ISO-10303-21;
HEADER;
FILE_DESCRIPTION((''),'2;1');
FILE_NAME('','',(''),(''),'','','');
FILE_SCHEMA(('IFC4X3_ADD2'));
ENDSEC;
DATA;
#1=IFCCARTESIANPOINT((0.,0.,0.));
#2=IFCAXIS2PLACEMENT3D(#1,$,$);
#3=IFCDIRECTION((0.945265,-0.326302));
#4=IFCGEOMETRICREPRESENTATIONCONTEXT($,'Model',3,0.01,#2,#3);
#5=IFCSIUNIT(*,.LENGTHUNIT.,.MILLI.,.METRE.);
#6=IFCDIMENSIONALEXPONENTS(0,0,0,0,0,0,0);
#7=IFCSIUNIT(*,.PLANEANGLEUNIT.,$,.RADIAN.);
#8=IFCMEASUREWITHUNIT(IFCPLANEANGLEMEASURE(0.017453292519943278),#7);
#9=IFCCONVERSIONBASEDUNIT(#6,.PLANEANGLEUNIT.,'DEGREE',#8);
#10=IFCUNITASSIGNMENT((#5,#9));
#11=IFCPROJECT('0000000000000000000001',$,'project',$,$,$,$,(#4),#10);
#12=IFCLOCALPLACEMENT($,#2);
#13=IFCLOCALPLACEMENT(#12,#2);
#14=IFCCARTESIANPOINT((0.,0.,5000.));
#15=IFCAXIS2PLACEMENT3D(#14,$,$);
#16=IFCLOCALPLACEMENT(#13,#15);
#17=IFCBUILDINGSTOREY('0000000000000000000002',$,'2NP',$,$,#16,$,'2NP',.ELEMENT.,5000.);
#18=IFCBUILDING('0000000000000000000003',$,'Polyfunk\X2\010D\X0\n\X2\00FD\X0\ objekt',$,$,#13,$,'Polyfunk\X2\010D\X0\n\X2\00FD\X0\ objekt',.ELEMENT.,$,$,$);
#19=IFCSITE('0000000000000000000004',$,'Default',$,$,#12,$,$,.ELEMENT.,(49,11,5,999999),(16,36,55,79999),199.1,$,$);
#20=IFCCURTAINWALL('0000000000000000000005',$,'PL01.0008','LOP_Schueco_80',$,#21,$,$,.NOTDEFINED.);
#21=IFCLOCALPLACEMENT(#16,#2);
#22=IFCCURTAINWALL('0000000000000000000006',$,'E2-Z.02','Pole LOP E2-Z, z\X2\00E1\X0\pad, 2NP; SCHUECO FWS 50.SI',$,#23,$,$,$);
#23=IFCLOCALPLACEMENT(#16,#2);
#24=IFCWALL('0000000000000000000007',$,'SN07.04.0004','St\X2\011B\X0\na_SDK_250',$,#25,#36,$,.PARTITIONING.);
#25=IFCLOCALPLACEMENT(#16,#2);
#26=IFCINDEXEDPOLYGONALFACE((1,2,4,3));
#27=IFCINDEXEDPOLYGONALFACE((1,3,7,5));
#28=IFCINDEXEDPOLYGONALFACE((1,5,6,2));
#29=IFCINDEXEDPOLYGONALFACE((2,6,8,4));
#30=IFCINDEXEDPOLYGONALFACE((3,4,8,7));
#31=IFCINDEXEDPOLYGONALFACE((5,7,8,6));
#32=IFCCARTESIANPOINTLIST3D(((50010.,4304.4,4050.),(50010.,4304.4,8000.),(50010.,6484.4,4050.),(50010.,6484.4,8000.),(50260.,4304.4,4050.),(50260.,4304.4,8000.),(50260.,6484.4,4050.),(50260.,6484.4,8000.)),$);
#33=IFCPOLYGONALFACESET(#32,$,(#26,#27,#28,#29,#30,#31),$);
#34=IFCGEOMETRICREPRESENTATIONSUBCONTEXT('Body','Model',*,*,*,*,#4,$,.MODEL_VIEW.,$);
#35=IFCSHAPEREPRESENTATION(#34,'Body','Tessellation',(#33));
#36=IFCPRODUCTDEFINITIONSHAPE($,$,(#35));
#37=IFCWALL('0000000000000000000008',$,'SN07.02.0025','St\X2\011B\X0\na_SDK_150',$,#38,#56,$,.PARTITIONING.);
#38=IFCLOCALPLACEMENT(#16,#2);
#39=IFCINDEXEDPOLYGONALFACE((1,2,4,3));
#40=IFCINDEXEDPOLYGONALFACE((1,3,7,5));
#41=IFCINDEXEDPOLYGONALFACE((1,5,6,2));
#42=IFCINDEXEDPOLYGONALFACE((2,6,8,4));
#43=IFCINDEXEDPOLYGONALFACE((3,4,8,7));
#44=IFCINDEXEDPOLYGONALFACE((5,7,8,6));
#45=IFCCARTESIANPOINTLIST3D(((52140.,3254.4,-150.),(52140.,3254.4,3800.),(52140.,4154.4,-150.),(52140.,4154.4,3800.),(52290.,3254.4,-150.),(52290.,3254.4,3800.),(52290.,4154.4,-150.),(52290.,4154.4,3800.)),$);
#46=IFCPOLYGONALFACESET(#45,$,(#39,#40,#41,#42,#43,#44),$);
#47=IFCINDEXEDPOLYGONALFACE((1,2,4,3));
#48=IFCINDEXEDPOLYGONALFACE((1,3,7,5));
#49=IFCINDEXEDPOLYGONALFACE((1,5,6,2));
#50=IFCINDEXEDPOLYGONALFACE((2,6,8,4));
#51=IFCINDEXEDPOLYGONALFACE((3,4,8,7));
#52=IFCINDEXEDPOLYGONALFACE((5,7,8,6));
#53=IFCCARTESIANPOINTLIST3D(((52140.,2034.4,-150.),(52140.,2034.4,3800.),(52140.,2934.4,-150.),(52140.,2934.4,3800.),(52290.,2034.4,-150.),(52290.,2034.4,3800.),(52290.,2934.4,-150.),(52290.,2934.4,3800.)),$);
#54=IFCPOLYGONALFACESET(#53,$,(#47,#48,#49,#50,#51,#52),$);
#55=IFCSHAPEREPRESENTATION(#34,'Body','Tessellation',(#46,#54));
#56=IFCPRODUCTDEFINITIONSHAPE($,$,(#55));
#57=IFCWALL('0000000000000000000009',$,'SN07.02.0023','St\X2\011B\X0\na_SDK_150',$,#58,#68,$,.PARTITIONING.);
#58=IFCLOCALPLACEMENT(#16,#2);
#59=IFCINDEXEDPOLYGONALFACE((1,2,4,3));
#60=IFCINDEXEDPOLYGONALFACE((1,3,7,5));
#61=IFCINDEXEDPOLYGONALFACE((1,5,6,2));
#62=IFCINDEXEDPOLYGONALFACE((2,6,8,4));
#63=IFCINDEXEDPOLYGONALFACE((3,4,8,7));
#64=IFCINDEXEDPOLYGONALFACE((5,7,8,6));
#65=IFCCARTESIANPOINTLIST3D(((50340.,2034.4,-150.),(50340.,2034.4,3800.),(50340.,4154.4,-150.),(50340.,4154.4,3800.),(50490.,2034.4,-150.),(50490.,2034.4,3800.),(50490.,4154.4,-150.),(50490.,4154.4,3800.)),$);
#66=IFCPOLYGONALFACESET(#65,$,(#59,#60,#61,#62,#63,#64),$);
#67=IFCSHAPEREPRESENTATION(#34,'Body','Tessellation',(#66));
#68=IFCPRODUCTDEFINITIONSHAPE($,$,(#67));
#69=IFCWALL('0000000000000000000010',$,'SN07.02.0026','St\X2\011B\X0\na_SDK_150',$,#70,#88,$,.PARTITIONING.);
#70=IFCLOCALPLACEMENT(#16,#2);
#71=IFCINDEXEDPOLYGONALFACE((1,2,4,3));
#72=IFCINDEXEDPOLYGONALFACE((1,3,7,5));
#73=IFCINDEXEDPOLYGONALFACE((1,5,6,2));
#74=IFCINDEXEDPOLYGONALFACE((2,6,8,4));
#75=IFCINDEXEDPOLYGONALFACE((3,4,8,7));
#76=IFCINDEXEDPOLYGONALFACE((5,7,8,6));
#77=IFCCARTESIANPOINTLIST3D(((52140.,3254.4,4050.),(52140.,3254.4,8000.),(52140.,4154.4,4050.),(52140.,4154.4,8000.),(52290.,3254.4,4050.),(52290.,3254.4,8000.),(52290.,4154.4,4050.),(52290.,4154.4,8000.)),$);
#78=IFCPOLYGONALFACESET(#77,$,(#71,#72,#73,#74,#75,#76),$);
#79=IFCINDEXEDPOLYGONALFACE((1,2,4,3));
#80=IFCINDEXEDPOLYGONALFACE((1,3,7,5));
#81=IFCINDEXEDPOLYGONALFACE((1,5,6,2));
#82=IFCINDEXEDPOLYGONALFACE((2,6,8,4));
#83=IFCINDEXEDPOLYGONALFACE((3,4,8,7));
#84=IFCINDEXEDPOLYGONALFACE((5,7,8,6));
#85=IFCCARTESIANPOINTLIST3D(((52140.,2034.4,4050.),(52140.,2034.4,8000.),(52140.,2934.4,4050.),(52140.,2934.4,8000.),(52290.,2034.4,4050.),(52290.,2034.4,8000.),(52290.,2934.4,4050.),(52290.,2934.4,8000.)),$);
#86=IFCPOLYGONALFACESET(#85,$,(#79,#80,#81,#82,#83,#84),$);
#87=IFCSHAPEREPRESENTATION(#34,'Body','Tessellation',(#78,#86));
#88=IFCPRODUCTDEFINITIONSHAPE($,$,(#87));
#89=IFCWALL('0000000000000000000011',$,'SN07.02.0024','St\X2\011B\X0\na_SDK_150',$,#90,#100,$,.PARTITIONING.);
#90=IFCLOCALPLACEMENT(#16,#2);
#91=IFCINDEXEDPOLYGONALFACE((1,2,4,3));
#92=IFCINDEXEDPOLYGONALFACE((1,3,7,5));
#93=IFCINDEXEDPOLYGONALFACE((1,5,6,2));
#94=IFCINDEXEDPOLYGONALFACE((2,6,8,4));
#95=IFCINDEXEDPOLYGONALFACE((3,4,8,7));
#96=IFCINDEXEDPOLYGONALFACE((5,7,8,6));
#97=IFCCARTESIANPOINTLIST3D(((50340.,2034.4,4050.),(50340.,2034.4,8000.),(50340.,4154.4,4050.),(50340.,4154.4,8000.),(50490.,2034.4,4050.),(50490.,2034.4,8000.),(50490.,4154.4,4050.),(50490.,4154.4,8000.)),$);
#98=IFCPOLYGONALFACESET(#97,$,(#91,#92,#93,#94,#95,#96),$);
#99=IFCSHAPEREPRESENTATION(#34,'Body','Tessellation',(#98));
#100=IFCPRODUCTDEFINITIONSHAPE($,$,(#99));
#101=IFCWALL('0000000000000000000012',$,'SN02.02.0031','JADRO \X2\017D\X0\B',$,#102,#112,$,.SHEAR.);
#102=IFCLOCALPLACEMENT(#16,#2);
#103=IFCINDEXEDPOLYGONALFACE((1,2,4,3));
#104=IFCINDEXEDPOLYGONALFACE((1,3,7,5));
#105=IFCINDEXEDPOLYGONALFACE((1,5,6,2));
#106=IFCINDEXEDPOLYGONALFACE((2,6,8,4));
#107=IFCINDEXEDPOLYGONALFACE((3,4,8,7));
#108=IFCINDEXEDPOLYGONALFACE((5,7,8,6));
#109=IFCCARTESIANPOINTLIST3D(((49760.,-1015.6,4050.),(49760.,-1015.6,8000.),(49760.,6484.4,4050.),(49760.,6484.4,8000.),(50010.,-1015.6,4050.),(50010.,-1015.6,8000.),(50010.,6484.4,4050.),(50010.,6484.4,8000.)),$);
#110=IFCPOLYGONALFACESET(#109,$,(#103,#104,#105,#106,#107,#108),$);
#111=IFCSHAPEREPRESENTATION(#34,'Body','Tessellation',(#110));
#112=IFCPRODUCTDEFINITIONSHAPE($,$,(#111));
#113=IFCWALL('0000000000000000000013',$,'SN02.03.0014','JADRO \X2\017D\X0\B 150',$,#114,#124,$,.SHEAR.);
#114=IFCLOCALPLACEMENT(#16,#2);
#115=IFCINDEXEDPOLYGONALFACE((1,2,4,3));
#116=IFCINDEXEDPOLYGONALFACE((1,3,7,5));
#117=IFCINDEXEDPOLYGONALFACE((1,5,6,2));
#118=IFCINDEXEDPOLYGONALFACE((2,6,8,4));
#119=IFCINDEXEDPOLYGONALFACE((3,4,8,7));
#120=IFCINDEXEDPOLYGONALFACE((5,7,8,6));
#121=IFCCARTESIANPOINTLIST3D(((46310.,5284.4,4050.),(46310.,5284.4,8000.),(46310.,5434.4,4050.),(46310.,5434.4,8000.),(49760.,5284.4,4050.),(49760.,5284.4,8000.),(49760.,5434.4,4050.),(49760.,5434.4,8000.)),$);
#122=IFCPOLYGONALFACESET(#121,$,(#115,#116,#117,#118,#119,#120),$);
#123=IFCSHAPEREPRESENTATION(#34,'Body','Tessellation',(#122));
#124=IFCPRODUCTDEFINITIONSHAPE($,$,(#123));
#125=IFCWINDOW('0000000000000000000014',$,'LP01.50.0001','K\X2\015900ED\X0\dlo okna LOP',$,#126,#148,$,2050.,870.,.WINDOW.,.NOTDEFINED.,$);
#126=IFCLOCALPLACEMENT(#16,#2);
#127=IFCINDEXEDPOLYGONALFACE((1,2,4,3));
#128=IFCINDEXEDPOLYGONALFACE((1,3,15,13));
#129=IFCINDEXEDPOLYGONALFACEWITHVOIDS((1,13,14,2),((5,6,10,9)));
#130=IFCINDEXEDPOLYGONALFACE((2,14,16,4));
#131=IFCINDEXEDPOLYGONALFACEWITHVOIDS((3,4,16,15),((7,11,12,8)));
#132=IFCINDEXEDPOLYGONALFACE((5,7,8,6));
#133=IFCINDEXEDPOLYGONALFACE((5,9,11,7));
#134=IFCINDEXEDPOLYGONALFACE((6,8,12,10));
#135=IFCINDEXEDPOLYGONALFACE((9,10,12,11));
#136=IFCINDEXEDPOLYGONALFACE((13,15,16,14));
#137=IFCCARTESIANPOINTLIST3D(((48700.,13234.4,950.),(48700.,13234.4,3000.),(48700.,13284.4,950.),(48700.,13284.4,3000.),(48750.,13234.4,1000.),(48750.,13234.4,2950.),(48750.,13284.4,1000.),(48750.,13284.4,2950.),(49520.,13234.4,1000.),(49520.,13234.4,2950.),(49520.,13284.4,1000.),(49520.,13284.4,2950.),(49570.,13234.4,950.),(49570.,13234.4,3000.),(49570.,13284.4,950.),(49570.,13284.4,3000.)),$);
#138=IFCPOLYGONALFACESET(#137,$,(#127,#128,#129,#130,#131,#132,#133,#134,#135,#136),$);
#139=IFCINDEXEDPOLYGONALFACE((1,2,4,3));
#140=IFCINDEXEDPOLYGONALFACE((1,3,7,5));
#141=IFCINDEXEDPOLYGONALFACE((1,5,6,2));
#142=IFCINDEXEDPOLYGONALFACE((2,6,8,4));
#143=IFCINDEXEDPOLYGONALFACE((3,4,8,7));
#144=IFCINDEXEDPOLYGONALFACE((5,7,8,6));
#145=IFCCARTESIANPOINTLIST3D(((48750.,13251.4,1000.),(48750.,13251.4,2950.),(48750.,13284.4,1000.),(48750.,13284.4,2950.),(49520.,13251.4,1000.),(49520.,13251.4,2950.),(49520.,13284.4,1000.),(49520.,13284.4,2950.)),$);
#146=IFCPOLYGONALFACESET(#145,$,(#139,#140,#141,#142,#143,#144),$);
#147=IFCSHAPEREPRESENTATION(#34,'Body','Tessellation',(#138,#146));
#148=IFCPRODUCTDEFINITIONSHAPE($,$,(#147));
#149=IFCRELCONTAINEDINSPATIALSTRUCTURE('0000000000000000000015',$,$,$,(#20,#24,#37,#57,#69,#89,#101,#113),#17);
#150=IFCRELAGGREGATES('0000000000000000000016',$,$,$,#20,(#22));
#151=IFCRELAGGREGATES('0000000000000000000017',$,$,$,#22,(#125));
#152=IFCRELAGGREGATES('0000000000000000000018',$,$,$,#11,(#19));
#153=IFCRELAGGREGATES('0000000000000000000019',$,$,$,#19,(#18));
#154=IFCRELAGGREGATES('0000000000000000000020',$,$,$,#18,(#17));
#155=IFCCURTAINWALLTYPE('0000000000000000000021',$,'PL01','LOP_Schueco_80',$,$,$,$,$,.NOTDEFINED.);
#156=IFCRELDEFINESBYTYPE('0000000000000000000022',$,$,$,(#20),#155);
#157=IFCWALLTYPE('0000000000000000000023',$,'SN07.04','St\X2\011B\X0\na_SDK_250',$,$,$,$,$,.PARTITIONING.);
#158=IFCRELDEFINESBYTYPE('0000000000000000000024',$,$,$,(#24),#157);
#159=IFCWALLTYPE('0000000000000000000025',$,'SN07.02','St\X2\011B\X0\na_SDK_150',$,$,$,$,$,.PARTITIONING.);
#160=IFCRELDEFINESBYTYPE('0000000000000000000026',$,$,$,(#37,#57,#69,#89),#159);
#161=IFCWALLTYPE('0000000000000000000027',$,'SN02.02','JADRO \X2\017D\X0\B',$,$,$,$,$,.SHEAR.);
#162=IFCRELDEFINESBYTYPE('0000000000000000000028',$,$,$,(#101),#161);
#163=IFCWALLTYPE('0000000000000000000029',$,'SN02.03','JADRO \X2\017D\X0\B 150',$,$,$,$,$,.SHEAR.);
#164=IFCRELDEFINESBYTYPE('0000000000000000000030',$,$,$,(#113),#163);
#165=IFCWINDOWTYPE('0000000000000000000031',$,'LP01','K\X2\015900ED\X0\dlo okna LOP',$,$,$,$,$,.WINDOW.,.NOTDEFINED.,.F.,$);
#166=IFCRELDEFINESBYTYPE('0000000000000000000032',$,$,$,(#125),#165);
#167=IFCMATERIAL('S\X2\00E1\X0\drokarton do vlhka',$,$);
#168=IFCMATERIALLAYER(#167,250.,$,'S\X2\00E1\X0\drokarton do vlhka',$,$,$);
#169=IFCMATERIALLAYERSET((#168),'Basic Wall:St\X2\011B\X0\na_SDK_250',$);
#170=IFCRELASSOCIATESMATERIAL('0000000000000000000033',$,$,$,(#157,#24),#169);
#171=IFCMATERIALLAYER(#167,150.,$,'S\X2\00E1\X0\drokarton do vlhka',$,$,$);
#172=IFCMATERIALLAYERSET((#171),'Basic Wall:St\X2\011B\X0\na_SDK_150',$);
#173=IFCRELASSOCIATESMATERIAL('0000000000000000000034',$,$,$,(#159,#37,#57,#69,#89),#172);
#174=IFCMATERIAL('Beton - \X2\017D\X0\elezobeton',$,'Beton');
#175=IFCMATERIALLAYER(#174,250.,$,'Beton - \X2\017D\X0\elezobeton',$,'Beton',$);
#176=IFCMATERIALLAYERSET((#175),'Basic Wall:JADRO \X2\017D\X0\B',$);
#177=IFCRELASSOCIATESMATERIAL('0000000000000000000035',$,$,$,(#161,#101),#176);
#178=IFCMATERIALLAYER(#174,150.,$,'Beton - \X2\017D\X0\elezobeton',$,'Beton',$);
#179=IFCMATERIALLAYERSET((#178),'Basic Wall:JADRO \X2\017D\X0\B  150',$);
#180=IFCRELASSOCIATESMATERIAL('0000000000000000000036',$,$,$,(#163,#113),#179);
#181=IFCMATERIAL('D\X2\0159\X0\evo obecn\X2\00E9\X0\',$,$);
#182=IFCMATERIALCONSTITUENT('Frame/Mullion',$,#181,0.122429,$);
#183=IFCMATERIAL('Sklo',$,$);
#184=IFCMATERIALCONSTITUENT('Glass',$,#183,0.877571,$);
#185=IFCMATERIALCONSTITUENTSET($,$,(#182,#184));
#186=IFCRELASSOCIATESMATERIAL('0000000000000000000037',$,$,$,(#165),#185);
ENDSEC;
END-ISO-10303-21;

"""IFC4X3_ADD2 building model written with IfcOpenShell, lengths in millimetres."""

from ifc_helpers import new_model, entity, si_unit, converted_unit, direction, frame, frame_2d, origin, origin_2d_with_axis, place, context, subcontext, project, spatial, polyline, rectangle, outline, extrude, clip, bounded_halfspace, source, transform, mapped, material, layer, layer_set, constituent, constituent_set, type_object, type_shapes, element, aggregate, save


model = new_model("IFC4X3_ADD2")

# Units and contexts
model_context = context("Model", 3, precision=0.01, world=origin(), true_north=direction((0.945265, -0.326302)))
body_context = subcontext(model_context, "Body", "Model", "MODEL_VIEW")
ifc_project = project(units=[si_unit("LENGTHUNIT", "METRE", prefix="MILLI"), converted_unit("PLANEANGLEUNIT", "DEGREE", entity("IfcPlaneAngleMeasure", 0.017453292519943278), si_unit("PLANEANGLEUNIT", "RADIAN"), dimensions=[0, 0, 0, 0, 0, 0, 0])], contexts=[model_context])

# Site, building, storey
site_placement = place(None, origin())
site = spatial("IfcSite", under=ifc_project, at=site_placement, Name="Default", CompositionType="ELEMENT", RefLatitude=(49, 11, 5, 999999), RefLongitude=(16, 36, 55, 79999), RefElevation=199.1)
building_placement = place(site_placement, origin())
building = spatial("IfcBuilding", under=site, at=building_placement, Name="Polyfunkčný objekt", LongName="Polyfunkčný objekt", CompositionType="ELEMENT")
storey_placement = place(building_placement, frame((0.0, 0.0, 5000.0)))
storey = spatial("IfcBuildingStorey", under=building, at=storey_placement, Name="2NP", LongName="2NP", CompositionType="ELEMENT", Elevation=5000.0)

# Curtain walls
curtain_wall_type = type_object("IfcCurtainWallType", Name="PL01", Description="LOP_Schueco_80", PredefinedType="NOTDEFINED")
curtain_wall_1_placement = place(storey_placement, frame((0.0, 0.0, -5000.0)))
curtain_wall_1 = element("IfcCurtainWall", 1, at=curtain_wall_1_placement, inside=storey, type_object=curtain_wall_type, Name="PL01.0008", Description="LOP_Schueco_80", PredefinedType="NOTDEFINED")
curtain_wall_2 = element("IfcCurtainWall", 2, Name="E2-Z.02", Description="Pole LOP E2-Z, západ, 2NP; SCHUECO FWS 50.SI")
aggregate(curtain_wall_1, [curtain_wall_2])
ifc_material_1 = material(Name="Sklo")

# Walls
ifc_material_2 = material(Name="Sádrokarton do vlhka")
ifc_layer_1 = layer(ifc_material_2, 250.0, Name="Sádrokarton do vlhka")
ifc_layer_set_1 = layer_set([ifc_layer_1], Name="Basic Wall:Stěna_SDK_250")
wall_type_1 = type_object("IfcWallType", Name="SN07.04", Description="Stěna_SDK_250", PredefinedType="PARTITIONING", material=ifc_layer_set_1)
wall_1_placement = place(storey_placement, frame((50135.0, 6484.4, 4050.0), z_axis=(0.0, 0.0, 1.0), x_axis=(0.0, -1.0, 0.0)))
element("IfcWall", 3, at=wall_1_placement, inside=storey, type_object=wall_type_1, material=ifc_layer_set_1, Name="SN07.04.0004", Description="Stěna_SDK_250", PredefinedType="PARTITIONING", context=body_context, shape_type="Clipping", body=[
    clip(clip(extrude(rectangle(XDim=2180.0, YDim=250.0, at=frame_2d((1090.0, 0.0), x_axis=(-1.0, 0.0))), origin(), (0.0, 0.0, 1.0), 3950.0), bounded_halfspace(frame((2180.0, -125.0, 0.0), z_axis=(0.0, 0.0, 1.0), x_axis=(0.0, -1.0, 0.0)), True, frame((2180.0, -125.0, 0.0)), polyline([(0.0, 0.0), (0.0, 250.0), (-1930.0, 250.0), (-2180.0, 250.0), (-2180.0, 0.0), (0.0, 0.0)]))), bounded_halfspace(frame((0.0, -125.0, 3950.0), z_axis=(0.0, 0.0, -1.0), x_axis=(0.0, 1.0, 0.0)), True, frame((0.0, -125.0, 3950.0)), polyline([(0.0, 0.0), (2180.0, 0.0), (2180.0, 250.0), (250.0, 250.0), (0.0, 250.0), (0.0, 0.0)]))),
])
ifc_layer_2 = layer(ifc_material_2, 150.0, Name="Sádrokarton do vlhka")
ifc_layer_set_2 = layer_set([ifc_layer_2], Name="Basic Wall:Stěna_SDK_150")
wall_type_2 = type_object("IfcWallType", Name="SN07.02", Description="Stěna_SDK_150", PredefinedType="PARTITIONING", material=ifc_layer_set_2)
wall_2_placement = place(storey_placement, frame((52215.0, 4154.4, -150.0), z_axis=(0.0, 0.0, 1.0), x_axis=(0.0, -1.0, 0.0)))
element("IfcWall", 4, at=wall_2_placement, inside=storey, type_object=wall_type_2, material=ifc_layer_set_2, Name="SN07.02.0025", Description="Stěna_SDK_150", PredefinedType="PARTITIONING", context=body_context, shape_type="SweptSolid", body=[
    extrude(rectangle(XDim=900.0, YDim=150.0, at=frame_2d((0.0, 0.0), x_axis=(1.0, 0.0))), frame((450.0, 0.0, 0.0)), (0.0, 0.0, 1.0), 3950.0),
    extrude(rectangle(XDim=900.0, YDim=150.0, at=frame_2d((0.0, 0.0), x_axis=(1.0, 0.0))), frame((1670.0, 0.0, 0.0), z_axis=(0.0, 0.0, 1.0), x_axis=(-1.0, 0.0, 0.0)), (0.0, 0.0, 1.0), 3950.0),
])
wall_3_placement = place(storey_placement, frame((50415.0, 4154.4, -150.0), z_axis=(0.0, 0.0, 1.0), x_axis=(0.0, -1.0, 0.0)))
element("IfcWall", 5, at=wall_3_placement, inside=storey, type_object=wall_type_2, material=ifc_layer_set_2, Name="SN07.02.0023", Description="Stěna_SDK_150", PredefinedType="PARTITIONING", context=body_context, shape_type="Clipping", body=[
    clip(clip(extrude(rectangle(XDim=2120.0, YDim=150.0, at=frame_2d((1060.0, 0.0), x_axis=(-1.0, 0.0))), origin(), (0.0, 0.0, 1.0), 3950.0), bounded_halfspace(frame((2120.0, -75.0, 0.0), z_axis=(0.0, 0.0, 1.0), x_axis=(0.0, -1.0, 0.0)), True, frame((2120.0, -75.0, 0.0)), polyline([(0.0, 0.0), (0.0, 150.0), (-900.0, 150.0), (-1220.0, 150.0), (-2120.0, 150.0), (-2120.0, 0.0), (0.0, 0.0)]))), bounded_halfspace(frame((0.0, -75.0, 3950.0), z_axis=(0.0, 0.0, -1.0), x_axis=(0.0, 1.0, 0.0)), True, frame((0.0, -75.0, 3950.0)), polyline([(0.0, 0.0), (2120.0, 0.0), (2120.0, 150.0), (1220.0, 150.0), (900.0, 150.0), (0.0, 150.0), (0.0, 0.0)]))),
])
wall_4_placement = place(storey_placement, frame((52215.0, 4154.4, 4050.0), z_axis=(0.0, 0.0, 1.0), x_axis=(0.0, -1.0, 0.0)))
element("IfcWall", 6, at=wall_4_placement, inside=storey, type_object=wall_type_2, material=ifc_layer_set_2, Name="SN07.02.0026", Description="Stěna_SDK_150", PredefinedType="PARTITIONING", context=body_context, shape_type="SweptSolid", body=[
    extrude(rectangle(XDim=900.0, YDim=150.0, at=frame_2d((0.0, 0.0), x_axis=(1.0, 0.0))), frame((450.0, 0.0, 0.0)), (0.0, 0.0, 1.0), 3950.0),
    extrude(rectangle(XDim=900.0, YDim=150.0, at=frame_2d((0.0, 0.0), x_axis=(1.0, 0.0))), frame((1670.0, 0.0, 0.0), z_axis=(0.0, 0.0, 1.0), x_axis=(-1.0, 0.0, 0.0)), (0.0, 0.0, 1.0), 3950.0),
])
wall_5_placement = place(storey_placement, frame((50415.0, 4154.4, 4050.0), z_axis=(0.0, 0.0, 1.0), x_axis=(0.0, -1.0, 0.0)))
element("IfcWall", 7, at=wall_5_placement, inside=storey, type_object=wall_type_2, material=ifc_layer_set_2, Name="SN07.02.0024", Description="Stěna_SDK_150", PredefinedType="PARTITIONING", context=body_context, shape_type="Clipping", body=[
    clip(clip(extrude(rectangle(XDim=2120.0, YDim=150.0, at=frame_2d((1060.0, 0.0), x_axis=(-1.0, 0.0))), origin(), (0.0, 0.0, 1.0), 3950.0), bounded_halfspace(frame((2120.0, -75.0, 0.0), z_axis=(0.0, 0.0, 1.0), x_axis=(0.0, -1.0, 0.0)), True, frame((2120.0, -75.0, 0.0)), polyline([(0.0, 0.0), (0.0, 150.0), (-900.0, 150.0), (-1220.0, 150.0), (-2120.0, 150.0), (-2120.0, 0.0), (0.0, 0.0)]))), bounded_halfspace(frame((0.0, -75.0, 3950.0), z_axis=(0.0, 0.0, -1.0), x_axis=(0.0, 1.0, 0.0)), True, frame((0.0, -75.0, 3950.0)), polyline([(0.0, 0.0), (2120.0, 0.0), (2120.0, 150.0), (1220.0, 150.0), (900.0, 150.0), (0.0, 150.0), (0.0, 0.0)]))),
])
ifc_material_3 = material(Name="Beton - Železobeton", Category="Beton")
ifc_layer_3 = layer(ifc_material_3, 250.0, Name="Beton - Železobeton", Category="Beton")
ifc_layer_set_3 = layer_set([ifc_layer_3], Name="Basic Wall:JADRO ŽB")
wall_type_3 = type_object("IfcWallType", Name="SN02.02", Description="JADRO ŽB", PredefinedType="SHEAR", material=ifc_layer_set_3)
wall_6_placement = place(storey_placement, frame((49885.0, 6484.4, 4050.0), z_axis=(0.0, 0.0, 1.0), x_axis=(0.0, -1.0, 0.0)))
element("IfcWall", 8, at=wall_6_placement, inside=storey, type_object=wall_type_3, material=ifc_layer_set_3, Name="SN02.02.0031", Description="JADRO ŽB", PredefinedType="SHEAR", context=body_context, shape_type="Clipping", body=[
    clip(clip(extrude(rectangle(XDim=7500.0, YDim=250.0, at=frame_2d((3750.0, 0.0), x_axis=(-1.0, 0.0))), origin(), (0.0, 0.0, 1.0), 3950.0), bounded_halfspace(frame((7500.0, -125.0, 0.0), z_axis=(0.0, 0.0, 1.0), x_axis=(0.0, -1.0, 0.0)), True, frame((7500.0, -125.0, 0.0)), polyline([(0.0, 0.0), (0.0, 250.0), (-7500.0, 250.0), (-7500.0, 0.0), (-7250.0, 0.0), (-6450.0, 0.0), (-6300.0, 0.0), (0.0, 0.0)]))), bounded_halfspace(frame((0.0, -125.0, 3950.0), z_axis=(0.0, 0.0, -1.0), x_axis=(0.0, 1.0, 0.0)), True, frame((0.0, -125.0, 3950.0)), polyline([(0.0, 0.0), (250.0, 0.0), (1050.0, 0.0), (1200.0, 0.0), (7500.0, 0.0), (7500.0, 250.0), (0.0, 250.0), (0.0, 0.0)]))),
])
ifc_layer_4 = layer(ifc_material_3, 150.0, Name="Beton - Železobeton", Category="Beton")
ifc_layer_set_4 = layer_set([ifc_layer_4], Name="Basic Wall:JADRO ŽB  150")
wall_type_4 = type_object("IfcWallType", Name="SN02.03", Description="JADRO ŽB 150", PredefinedType="SHEAR", material=ifc_layer_set_4)
wall_7_placement = place(storey_placement, frame((46310.0, 5359.4, 4050.0)))
element("IfcWall", 9, at=wall_7_placement, inside=storey, type_object=wall_type_4, material=ifc_layer_set_4, Name="SN02.03.0014", Description="JADRO ŽB 150", PredefinedType="SHEAR", context=body_context, shape_type="SweptSolid", body=[
    extrude(rectangle(XDim=3450.0, YDim=150.0, at=frame_2d((1725.0, 0.0), x_axis=(-1.0, 0.0))), origin(), (0.0, 0.0, 1.0), 3950.0),
])

# Window
ifc_material_4 = material(Name="Dřevo obecné")
ifc_constituent_1 = constituent(ifc_material_4, Name="Frame/Mullion", fraction=0.122429)
ifc_constituent_2 = constituent(ifc_material_1, Name="Glass", fraction=0.877571)
ifc_constituent_set = constituent_set(constituents=[ifc_constituent_1, ifc_constituent_2])
window_type = type_object("IfcWindowType", Name="LP01", Description="Křídlo okna LOP", ParameterTakesPrecedence=False, PartitioningType="NOTDEFINED", PredefinedType="WINDOW", material=ifc_constituent_set)
shared_shape_1 = source(origin(), body_context, "Body", "SweptSolid", [
    extrude(outline(polyline([(-1025.0, -435.0), (1025.0, -435.0), (1025.0, 435.0), (-1025.0, 435.0), (-1025.0, -435.0)]), holes=[polyline([(-975.0, -385.0), (-975.0, 385.0), (975.0, 385.0), (975.0, -385.0), (-975.0, -385.0)])]), frame((0.0, 0.0, 1025.0), z_axis=(0.0, 1.0, 0.0), x_axis=(0.0, 0.0, -1.0)), (0.0, 0.0, 1.0), 50.0),
    extrude(rectangle(XDim=33.0, YDim=770.0, at=origin_2d_with_axis()), frame((0.0, 33.5, 50.0), z_axis=(0.0, 0.0, 1.0), x_axis=(0.0, -1.0, 0.0)), (0.0, 0.0, 1.0), 1950.0),
])
type_shapes(window_type, [shared_shape_1])
window_placement = place(curtain_wall_1_placement, frame((49135.0, 13234.4, 5950.0)))
window = element("IfcWindow", 10, at=window_placement, type_object=window_type, Name="LP01.50.0001", Description="Křídlo okna LOP", OverallHeight=2050.0, OverallWidth=870.0, PartitioningType="NOTDEFINED", PredefinedType="WINDOW", context=body_context, shape_type="MappedRepresentation", body=[
    mapped(shared_shape_1, transform((0.0, 0.0, 0.0), scale=1.0)),
])
aggregate(curtain_wall_2, [window])

save(model, "model.ifc")
